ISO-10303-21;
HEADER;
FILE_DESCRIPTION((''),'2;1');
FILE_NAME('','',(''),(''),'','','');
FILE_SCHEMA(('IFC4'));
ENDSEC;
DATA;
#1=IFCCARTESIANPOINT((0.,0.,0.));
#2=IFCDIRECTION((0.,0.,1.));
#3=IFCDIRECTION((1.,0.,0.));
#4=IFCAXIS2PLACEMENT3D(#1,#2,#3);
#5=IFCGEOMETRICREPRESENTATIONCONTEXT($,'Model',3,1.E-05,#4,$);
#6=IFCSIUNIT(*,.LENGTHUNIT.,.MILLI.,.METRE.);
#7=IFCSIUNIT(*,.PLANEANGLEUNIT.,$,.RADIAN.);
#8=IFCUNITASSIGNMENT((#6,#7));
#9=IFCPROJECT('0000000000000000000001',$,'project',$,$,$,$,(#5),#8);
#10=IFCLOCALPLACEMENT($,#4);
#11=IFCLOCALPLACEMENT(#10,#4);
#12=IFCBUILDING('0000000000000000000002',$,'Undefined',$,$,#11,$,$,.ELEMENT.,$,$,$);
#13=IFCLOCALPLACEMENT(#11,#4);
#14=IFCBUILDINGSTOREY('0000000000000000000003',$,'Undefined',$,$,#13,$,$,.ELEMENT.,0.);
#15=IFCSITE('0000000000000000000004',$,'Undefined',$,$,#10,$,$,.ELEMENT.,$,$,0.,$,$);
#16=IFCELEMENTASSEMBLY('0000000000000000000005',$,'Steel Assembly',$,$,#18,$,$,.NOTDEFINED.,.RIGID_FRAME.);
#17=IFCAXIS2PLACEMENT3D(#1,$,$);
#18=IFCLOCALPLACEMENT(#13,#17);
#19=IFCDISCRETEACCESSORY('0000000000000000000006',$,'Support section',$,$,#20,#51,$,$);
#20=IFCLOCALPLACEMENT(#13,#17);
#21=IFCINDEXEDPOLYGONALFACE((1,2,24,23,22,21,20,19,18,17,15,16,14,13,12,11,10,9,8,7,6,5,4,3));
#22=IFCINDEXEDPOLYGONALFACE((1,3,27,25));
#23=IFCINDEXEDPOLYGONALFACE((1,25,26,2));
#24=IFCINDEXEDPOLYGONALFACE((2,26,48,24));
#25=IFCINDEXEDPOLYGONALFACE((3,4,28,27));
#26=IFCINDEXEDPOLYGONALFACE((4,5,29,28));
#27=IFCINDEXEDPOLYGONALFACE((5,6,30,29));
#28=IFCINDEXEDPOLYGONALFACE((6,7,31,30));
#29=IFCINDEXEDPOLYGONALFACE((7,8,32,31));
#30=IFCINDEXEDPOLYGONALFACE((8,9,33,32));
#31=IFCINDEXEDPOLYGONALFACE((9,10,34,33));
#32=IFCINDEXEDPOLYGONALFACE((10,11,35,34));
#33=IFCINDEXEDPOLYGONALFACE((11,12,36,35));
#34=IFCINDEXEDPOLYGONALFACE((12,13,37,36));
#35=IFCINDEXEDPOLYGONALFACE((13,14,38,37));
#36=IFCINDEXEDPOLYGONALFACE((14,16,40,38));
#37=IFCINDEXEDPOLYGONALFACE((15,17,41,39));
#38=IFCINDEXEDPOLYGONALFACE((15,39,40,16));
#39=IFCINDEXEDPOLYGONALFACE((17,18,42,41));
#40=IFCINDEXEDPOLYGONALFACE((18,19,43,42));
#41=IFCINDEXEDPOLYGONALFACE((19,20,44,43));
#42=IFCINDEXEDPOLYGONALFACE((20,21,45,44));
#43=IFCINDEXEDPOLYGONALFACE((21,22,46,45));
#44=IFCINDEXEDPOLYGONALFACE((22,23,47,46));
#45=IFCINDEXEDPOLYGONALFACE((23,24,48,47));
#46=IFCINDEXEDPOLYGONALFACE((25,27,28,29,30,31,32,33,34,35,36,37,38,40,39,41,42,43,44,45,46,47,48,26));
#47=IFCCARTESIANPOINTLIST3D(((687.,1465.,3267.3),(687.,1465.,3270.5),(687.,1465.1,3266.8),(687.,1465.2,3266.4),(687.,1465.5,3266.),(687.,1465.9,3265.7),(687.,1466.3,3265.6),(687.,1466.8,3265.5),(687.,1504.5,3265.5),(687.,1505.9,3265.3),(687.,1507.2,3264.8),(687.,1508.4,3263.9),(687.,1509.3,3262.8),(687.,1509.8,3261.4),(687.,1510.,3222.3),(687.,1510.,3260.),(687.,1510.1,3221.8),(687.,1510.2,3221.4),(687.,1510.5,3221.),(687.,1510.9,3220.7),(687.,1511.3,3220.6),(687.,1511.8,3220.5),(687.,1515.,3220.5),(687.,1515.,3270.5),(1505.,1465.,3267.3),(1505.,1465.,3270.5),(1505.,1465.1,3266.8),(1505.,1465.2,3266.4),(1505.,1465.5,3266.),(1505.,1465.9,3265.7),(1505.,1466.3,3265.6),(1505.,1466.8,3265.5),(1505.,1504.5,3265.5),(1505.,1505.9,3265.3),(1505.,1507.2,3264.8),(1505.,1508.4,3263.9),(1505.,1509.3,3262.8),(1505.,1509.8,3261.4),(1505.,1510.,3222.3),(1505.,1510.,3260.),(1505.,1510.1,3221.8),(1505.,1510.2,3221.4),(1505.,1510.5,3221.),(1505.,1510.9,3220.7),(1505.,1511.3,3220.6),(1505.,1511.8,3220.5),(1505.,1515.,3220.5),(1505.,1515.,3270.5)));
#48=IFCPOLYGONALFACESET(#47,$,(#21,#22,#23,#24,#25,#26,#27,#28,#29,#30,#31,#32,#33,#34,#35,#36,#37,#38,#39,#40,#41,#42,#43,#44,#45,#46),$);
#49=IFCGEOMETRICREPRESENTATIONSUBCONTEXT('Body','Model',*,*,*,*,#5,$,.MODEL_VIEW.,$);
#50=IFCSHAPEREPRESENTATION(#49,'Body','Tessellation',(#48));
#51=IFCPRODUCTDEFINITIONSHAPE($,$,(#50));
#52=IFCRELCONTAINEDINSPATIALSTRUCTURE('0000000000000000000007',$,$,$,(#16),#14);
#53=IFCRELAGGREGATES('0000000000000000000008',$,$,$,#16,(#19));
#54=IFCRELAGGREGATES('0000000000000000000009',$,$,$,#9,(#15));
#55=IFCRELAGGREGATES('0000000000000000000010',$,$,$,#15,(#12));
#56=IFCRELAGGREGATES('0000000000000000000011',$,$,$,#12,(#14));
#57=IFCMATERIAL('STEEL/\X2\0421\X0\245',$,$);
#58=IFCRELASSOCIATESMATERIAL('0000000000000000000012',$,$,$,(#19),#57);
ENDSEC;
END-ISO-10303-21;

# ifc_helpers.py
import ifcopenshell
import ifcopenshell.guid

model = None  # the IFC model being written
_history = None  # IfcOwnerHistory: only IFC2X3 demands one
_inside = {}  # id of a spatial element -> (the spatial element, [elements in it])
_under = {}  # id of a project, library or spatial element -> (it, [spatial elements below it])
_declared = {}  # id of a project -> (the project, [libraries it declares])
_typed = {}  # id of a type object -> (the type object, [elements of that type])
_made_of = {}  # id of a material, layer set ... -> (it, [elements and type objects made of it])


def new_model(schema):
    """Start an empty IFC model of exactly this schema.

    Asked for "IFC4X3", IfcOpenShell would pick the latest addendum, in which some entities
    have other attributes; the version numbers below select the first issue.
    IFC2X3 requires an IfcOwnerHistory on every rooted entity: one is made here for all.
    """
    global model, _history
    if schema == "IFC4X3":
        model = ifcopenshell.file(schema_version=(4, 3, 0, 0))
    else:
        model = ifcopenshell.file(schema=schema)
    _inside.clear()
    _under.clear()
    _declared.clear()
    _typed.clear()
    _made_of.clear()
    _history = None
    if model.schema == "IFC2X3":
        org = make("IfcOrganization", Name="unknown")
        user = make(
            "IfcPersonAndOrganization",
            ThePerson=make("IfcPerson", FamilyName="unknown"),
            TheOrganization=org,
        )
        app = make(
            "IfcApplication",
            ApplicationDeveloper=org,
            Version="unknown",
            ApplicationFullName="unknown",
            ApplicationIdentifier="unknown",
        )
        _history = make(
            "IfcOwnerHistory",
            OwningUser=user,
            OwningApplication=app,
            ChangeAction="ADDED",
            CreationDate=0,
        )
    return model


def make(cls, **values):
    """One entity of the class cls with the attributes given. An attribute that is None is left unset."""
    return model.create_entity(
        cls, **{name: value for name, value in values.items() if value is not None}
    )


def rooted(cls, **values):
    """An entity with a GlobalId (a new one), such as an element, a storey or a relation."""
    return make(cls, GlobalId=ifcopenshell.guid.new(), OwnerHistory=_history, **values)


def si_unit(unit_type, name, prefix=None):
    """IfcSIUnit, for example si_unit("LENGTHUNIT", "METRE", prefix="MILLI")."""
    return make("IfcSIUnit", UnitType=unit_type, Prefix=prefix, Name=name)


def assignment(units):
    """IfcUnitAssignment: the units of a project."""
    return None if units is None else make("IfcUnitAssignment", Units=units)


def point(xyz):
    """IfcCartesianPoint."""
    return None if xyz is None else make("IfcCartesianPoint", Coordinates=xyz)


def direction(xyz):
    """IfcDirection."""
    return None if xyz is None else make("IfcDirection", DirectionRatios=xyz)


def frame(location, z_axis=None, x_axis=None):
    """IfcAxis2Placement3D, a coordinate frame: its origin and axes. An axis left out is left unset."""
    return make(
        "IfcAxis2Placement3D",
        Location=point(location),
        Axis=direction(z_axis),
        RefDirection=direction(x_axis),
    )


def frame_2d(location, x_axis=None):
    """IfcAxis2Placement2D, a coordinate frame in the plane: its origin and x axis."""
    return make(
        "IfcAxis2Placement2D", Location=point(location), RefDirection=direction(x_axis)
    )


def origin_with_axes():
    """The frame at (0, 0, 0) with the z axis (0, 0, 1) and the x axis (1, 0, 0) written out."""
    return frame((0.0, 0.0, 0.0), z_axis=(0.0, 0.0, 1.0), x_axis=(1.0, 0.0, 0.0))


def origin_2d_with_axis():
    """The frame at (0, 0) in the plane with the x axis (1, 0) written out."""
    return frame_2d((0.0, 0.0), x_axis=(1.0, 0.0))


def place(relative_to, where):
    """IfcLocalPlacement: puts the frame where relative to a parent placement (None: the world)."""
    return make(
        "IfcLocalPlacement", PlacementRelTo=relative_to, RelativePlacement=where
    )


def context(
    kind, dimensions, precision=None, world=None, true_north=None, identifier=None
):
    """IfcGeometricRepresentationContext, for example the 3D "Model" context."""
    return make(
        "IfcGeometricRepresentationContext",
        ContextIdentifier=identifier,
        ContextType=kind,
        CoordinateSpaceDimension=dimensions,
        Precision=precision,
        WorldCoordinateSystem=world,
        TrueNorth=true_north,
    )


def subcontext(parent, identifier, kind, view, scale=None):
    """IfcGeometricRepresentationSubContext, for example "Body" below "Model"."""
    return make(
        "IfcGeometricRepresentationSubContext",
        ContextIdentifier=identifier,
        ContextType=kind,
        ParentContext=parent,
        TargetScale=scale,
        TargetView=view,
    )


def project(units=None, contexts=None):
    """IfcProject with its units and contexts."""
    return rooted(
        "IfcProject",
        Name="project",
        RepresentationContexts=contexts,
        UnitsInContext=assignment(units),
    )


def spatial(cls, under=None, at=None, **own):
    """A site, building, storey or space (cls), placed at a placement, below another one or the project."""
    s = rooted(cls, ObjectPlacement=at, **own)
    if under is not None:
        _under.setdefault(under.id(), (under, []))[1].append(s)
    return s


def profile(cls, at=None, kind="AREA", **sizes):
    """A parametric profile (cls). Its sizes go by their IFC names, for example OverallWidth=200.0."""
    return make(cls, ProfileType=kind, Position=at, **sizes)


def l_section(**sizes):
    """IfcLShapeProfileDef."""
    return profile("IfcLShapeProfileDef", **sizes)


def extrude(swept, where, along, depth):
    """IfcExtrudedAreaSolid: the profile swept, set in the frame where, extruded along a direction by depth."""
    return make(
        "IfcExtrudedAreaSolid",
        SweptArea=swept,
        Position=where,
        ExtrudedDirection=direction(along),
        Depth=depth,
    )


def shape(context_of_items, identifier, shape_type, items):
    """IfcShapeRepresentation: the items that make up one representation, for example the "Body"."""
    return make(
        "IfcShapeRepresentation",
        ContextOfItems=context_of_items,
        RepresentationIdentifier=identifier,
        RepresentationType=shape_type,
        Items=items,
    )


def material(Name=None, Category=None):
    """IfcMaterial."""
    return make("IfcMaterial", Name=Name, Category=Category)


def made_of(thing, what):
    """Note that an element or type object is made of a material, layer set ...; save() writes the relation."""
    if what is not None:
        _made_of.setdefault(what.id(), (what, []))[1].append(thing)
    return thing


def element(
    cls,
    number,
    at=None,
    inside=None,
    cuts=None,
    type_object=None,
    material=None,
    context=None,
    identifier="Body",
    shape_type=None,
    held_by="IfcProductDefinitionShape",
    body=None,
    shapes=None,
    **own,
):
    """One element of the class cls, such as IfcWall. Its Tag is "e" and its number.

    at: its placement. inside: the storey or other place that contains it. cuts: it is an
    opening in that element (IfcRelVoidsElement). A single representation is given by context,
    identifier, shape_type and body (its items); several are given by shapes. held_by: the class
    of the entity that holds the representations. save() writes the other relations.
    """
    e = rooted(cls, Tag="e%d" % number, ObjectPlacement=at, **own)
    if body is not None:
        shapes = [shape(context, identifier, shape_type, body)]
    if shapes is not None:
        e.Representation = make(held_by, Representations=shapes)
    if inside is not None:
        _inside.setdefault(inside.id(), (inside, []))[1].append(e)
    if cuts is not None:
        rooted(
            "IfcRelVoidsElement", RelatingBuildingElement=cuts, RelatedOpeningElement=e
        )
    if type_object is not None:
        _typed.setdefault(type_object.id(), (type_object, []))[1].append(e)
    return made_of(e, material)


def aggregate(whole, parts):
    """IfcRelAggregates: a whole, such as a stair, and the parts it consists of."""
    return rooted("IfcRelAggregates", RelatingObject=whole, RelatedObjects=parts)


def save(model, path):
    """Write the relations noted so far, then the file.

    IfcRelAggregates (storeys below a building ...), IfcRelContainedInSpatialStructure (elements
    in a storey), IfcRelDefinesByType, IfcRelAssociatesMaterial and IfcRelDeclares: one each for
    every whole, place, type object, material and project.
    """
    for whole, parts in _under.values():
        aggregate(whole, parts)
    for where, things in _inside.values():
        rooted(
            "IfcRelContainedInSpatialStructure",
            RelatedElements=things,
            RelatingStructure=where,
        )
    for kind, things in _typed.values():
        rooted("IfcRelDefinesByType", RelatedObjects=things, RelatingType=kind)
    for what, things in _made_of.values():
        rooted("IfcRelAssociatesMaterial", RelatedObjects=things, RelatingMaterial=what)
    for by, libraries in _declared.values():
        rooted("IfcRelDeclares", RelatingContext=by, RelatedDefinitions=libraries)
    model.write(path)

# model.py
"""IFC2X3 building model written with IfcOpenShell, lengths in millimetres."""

from ifc_helpers import new_model, si_unit, frame, origin_with_axes, origin_2d_with_axis, place, context, subcontext, project, spatial, l_section, extrude, material, element, aggregate, save


model = new_model("IFC2X3")

# Units and contexts
model_context = context("Model", 3, precision=1e-05, world=origin_with_axes())
body_context = subcontext(model_context, "Body", "Model", "MODEL_VIEW")
ifc_project = project(units=[si_unit("LENGTHUNIT", "METRE", prefix="MILLI"), si_unit("PLANEANGLEUNIT", "RADIAN")], contexts=[model_context])

# Site, building, storey
site_placement = place(None, origin_with_axes())
site = spatial("IfcSite", under=ifc_project, at=site_placement, Name="Undefined", CompositionType="ELEMENT", RefElevation=0.0)
building_placement = place(site_placement, origin_with_axes())
building = spatial("IfcBuilding", under=site, at=building_placement, Name="Undefined", CompositionType="ELEMENT")
storey_placement = place(building_placement, origin_with_axes())
storey = spatial("IfcBuildingStorey", under=building, at=storey_placement, Name="Undefined", CompositionType="ELEMENT", Elevation=0.0)

# Element assembly
assembly_1_placement = place(storey_placement, origin_with_axes())
assembly_1 = element("IfcElementAssembly", 1, at=assembly_1_placement, inside=storey, Name="Steel Assembly", AssemblyPlace="NOTDEFINED", PredefinedType="RIGID_FRAME")
ifc_material_1 = material(Name="STEEL/С245")

# Discrete accessory
discrete_accessory_1_placement = place(assembly_1_placement, frame((687.0, 1490.0, 3245.5), z_axis=(0.0, -1.0, 0.0), x_axis=(1.0, 0.0, 0.0)))
discrete_accessory_1 = element("IfcDiscreteAccessory", 2, at=discrete_accessory_1_placement, material=ifc_material_1, Name="Support section", context=body_context, shape_type="SweptSolid", body=[
    extrude(l_section(Depth=50.0, Width=50.0, Thickness=5.0, FilletRadius=5.5, EdgeRadius=1.8, at=origin_2d_with_axis()), frame((818.0, 0.0, 0.0), z_axis=(-1.0, 0.0, 0.0), x_axis=(0.0, -1.0, 0.0)), (0.0, 0.0, 1.0), 818.0),
])
aggregate(assembly_1, [discrete_accessory_1])

save(model, "model.ifc")
